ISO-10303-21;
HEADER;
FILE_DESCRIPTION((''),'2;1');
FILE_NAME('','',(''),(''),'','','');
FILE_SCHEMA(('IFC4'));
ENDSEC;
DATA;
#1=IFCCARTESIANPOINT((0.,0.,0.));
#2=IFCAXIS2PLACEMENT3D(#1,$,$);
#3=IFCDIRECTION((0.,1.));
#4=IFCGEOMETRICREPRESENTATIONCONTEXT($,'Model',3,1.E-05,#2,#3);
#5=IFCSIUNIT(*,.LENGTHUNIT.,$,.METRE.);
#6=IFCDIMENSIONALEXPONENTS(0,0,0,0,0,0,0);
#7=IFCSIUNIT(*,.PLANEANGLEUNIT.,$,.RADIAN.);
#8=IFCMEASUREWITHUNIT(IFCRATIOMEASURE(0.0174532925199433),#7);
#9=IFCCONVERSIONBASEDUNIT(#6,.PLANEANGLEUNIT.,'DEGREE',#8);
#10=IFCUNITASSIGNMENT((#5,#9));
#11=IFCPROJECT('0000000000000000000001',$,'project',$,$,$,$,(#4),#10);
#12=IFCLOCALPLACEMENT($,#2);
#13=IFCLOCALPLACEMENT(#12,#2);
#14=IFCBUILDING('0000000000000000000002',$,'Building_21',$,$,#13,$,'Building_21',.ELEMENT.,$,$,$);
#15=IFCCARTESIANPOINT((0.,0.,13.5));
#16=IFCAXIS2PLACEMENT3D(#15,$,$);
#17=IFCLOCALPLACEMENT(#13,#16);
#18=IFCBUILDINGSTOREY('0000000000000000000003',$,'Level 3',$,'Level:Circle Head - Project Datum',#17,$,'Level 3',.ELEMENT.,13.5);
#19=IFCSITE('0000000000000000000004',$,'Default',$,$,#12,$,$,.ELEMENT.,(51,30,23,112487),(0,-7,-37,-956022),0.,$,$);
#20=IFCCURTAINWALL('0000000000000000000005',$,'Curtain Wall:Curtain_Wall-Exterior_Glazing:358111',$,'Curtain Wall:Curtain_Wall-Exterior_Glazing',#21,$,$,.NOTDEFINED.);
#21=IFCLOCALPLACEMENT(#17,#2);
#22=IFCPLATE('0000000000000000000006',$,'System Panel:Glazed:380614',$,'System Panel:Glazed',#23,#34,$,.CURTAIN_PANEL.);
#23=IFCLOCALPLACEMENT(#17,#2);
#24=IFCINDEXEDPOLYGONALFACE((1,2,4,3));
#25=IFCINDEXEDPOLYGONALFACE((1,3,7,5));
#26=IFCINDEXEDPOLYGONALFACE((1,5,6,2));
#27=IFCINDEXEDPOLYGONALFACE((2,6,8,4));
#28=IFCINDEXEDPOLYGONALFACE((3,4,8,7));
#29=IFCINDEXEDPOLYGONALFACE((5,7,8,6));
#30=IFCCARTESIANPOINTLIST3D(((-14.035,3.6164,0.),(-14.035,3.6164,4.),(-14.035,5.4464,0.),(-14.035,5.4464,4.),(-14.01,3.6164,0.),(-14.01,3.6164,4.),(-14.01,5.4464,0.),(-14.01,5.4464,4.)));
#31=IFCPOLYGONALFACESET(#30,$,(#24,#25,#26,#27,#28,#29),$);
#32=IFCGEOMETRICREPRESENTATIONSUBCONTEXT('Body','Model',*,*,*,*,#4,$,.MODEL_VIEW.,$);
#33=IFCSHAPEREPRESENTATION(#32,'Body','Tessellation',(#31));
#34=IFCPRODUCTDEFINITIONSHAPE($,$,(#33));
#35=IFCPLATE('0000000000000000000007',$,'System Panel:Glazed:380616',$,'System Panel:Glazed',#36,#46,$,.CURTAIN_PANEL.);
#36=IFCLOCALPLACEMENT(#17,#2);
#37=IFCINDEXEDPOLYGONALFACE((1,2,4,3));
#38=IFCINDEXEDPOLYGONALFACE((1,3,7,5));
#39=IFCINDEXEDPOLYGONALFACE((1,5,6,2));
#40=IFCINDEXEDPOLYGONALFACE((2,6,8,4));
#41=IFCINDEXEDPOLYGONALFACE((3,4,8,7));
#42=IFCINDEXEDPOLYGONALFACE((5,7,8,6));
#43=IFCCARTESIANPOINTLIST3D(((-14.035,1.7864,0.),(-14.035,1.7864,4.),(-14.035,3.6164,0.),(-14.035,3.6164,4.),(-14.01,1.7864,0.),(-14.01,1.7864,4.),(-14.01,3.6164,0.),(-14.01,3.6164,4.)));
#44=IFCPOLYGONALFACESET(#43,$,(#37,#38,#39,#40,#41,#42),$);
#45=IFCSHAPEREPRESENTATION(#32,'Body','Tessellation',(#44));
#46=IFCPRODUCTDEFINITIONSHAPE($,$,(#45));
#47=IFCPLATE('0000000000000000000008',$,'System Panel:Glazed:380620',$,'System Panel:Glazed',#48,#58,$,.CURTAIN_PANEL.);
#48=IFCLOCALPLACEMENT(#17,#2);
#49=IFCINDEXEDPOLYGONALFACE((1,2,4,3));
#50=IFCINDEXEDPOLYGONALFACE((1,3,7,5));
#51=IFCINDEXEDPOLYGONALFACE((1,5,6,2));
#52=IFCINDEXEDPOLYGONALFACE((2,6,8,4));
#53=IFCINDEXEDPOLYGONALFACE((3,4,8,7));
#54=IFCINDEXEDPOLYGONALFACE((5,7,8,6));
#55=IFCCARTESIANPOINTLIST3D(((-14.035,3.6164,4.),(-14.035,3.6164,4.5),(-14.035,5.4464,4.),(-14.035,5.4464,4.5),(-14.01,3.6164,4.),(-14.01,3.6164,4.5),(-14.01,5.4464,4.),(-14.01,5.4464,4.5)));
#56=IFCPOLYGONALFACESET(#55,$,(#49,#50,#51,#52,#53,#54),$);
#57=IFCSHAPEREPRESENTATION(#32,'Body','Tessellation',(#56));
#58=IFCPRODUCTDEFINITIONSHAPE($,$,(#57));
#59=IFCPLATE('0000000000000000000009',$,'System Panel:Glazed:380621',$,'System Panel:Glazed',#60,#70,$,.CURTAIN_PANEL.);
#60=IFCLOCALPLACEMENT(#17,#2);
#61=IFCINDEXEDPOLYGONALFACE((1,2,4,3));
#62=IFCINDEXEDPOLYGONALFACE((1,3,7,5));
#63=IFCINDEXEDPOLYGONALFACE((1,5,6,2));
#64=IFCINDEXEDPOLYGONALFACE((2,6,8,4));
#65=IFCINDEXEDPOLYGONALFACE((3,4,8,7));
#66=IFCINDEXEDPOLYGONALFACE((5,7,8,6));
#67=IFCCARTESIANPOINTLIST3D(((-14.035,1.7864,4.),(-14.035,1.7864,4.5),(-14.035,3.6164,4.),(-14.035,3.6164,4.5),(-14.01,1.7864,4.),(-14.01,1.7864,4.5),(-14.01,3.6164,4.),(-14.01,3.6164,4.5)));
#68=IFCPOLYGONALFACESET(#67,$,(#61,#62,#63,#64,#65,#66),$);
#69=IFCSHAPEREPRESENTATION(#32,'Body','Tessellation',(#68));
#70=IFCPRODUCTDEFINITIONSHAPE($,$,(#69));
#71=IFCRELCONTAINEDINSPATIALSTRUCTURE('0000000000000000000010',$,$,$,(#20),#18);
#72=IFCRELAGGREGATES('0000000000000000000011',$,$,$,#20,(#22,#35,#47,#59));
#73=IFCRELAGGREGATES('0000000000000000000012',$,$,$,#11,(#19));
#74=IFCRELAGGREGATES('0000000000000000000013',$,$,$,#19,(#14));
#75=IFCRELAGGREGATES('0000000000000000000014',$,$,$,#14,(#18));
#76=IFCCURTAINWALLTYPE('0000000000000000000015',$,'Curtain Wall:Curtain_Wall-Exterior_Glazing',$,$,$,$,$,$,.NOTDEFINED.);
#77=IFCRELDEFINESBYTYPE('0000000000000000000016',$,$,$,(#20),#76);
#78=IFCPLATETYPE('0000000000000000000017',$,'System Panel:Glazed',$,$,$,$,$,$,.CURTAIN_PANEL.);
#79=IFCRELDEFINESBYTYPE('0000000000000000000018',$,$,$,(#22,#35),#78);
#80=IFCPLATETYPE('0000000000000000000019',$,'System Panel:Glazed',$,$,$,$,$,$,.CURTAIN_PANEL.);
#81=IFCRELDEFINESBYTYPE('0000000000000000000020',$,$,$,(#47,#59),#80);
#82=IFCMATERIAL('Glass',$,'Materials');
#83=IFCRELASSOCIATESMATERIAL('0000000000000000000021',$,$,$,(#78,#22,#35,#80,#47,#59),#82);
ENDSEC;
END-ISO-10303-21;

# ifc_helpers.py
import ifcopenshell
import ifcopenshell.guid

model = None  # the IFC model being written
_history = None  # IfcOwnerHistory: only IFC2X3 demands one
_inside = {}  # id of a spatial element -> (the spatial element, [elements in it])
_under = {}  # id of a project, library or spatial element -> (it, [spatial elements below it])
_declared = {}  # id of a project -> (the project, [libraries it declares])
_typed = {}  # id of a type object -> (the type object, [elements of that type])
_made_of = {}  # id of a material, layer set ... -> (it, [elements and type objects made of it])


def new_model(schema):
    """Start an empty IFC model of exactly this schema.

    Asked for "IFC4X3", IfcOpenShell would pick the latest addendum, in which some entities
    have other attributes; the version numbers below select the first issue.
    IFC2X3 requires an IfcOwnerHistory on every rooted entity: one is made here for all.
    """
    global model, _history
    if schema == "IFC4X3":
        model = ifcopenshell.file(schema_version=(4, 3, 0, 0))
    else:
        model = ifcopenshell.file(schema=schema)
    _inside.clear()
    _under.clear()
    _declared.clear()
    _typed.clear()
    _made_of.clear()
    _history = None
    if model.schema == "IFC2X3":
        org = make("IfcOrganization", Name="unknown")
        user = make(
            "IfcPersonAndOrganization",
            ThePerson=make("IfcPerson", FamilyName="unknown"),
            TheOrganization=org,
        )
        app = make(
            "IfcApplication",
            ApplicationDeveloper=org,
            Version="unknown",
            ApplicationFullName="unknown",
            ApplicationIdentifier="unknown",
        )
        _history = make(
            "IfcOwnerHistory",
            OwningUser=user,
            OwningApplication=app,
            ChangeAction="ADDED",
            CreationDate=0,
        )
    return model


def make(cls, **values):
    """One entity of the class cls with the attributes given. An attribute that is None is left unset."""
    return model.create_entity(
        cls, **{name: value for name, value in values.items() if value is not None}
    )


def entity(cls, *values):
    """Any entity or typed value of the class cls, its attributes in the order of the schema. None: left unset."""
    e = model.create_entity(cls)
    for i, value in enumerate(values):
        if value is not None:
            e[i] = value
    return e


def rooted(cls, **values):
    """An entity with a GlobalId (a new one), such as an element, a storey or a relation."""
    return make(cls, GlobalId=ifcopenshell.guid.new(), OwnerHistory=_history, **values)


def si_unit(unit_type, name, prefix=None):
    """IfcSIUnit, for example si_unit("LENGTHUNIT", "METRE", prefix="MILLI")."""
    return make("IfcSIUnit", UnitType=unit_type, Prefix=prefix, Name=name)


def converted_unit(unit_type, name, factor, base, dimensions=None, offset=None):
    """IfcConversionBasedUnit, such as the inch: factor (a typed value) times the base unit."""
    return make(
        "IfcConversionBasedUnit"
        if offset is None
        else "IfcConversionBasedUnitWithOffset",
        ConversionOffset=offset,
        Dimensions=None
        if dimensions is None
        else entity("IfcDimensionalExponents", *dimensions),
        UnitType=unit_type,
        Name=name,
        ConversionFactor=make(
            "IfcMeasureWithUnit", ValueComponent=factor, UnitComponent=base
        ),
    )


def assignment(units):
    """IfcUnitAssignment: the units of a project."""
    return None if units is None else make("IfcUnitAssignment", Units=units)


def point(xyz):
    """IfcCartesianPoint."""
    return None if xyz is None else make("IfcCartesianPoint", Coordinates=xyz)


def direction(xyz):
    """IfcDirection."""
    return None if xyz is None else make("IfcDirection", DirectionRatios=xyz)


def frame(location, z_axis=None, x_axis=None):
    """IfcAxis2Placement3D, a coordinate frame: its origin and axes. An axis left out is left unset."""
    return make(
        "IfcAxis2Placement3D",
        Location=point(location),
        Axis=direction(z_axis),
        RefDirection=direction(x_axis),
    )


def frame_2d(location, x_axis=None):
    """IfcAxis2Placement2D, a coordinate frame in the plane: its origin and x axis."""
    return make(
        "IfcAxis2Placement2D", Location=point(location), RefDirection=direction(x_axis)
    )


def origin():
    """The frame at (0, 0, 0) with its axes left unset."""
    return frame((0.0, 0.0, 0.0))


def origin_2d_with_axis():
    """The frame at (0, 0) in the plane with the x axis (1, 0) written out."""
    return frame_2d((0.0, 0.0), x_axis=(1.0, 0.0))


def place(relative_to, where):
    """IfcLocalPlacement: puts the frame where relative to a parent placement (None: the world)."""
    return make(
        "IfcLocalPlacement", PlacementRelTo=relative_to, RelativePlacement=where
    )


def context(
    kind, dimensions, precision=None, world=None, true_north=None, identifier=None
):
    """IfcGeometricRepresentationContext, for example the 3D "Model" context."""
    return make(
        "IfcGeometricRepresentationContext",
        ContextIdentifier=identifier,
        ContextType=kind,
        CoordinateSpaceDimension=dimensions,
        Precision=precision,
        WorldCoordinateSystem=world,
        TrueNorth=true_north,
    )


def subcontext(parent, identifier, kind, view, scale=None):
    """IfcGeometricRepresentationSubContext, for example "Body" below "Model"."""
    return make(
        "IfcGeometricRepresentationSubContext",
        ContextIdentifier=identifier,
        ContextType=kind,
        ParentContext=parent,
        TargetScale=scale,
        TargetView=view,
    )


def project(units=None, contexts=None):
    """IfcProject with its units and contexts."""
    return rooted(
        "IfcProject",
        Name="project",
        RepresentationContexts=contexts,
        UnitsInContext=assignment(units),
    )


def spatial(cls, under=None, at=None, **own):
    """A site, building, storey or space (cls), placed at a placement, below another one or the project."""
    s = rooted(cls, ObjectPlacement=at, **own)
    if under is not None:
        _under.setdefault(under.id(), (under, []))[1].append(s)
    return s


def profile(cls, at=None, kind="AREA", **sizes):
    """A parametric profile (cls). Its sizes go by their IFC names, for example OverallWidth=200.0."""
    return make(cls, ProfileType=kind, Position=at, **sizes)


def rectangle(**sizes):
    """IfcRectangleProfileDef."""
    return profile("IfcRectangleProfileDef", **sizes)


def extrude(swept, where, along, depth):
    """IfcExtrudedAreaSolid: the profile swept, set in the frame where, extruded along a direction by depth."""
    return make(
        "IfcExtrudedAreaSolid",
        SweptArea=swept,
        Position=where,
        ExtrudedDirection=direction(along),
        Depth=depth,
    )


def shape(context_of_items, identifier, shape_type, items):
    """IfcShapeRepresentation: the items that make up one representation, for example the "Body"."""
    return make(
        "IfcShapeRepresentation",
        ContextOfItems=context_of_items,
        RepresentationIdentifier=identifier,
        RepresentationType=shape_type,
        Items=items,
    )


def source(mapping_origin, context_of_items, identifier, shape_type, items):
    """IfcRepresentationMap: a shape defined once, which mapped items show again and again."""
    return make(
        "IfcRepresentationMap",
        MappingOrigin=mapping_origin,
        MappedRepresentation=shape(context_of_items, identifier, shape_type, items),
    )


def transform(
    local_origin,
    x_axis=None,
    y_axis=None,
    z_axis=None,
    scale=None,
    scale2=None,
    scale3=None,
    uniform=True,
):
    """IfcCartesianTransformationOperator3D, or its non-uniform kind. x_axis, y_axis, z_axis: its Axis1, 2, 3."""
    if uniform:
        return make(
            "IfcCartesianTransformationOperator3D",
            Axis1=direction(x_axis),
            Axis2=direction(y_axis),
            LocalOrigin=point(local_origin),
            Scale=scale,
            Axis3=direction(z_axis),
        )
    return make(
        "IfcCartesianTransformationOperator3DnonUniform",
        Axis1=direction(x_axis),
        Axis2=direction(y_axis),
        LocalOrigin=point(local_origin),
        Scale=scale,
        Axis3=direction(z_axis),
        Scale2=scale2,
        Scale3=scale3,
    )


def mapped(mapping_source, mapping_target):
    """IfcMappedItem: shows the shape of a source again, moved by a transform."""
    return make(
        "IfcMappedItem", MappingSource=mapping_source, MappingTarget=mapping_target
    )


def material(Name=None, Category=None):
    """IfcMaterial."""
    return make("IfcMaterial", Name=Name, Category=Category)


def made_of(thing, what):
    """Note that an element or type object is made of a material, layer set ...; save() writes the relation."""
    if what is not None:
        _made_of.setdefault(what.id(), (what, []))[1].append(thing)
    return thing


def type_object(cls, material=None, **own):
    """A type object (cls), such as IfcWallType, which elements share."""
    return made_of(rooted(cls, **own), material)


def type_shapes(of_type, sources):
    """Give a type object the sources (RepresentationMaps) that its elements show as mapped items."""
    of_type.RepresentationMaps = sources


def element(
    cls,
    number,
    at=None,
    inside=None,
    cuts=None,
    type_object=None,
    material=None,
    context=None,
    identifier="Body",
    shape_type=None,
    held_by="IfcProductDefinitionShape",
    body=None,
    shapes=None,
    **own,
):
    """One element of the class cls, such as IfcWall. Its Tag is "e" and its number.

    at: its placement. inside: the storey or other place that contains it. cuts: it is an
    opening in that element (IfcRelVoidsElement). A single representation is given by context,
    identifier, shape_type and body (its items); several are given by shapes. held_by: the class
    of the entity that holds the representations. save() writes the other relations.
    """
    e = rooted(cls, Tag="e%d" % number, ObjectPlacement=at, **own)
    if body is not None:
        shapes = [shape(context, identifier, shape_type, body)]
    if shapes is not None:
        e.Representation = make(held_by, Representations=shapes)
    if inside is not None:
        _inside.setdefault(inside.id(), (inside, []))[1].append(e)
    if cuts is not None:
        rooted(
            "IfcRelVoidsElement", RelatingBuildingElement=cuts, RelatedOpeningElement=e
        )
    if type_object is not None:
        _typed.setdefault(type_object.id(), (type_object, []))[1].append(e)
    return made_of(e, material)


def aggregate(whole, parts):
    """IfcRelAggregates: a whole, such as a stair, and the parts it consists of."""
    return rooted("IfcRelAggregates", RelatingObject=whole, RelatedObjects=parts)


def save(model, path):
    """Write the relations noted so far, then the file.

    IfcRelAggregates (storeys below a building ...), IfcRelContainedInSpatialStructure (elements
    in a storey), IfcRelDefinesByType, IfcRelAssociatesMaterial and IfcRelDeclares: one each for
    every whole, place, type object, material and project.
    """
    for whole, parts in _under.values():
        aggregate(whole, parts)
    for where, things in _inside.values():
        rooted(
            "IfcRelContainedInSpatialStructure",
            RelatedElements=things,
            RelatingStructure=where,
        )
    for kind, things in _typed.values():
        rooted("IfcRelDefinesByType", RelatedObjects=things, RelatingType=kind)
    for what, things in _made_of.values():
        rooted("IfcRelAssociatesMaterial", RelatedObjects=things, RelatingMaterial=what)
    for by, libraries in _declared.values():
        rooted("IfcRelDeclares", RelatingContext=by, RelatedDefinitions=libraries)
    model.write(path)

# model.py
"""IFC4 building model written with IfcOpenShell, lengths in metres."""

from ifc_helpers import new_model, entity, si_unit, converted_unit, direction, frame, origin, origin_2d_with_axis, place, context, subcontext, project, spatial, rectangle, extrude, source, transform, mapped, material, type_object, type_shapes, element, aggregate, save


model = new_model("IFC4")

# Units and contexts
model_context = context("Model", 3, precision=1e-05, world=origin(), true_north=direction((0.0, 1.0)))
body_context = subcontext(model_context, "Body", "Model", "MODEL_VIEW")
ifc_project = project(units=[si_unit("LENGTHUNIT", "METRE"), converted_unit("PLANEANGLEUNIT", "DEGREE", entity("IfcRatioMeasure", 0.0174532925199433), si_unit("PLANEANGLEUNIT", "RADIAN"), dimensions=[0, 0, 0, 0, 0, 0, 0])], contexts=[model_context])

# Site, building, storey
site_placement = place(None, origin())
site = spatial("IfcSite", under=ifc_project, at=site_placement, Name="Default", CompositionType="ELEMENT", RefLatitude=(51, 30, 23, 112487), RefLongitude=(0, -7, -37, -956022), RefElevation=0.0)
building_placement = place(site_placement, origin())
building = spatial("IfcBuilding", under=site, at=building_placement, Name="Building_21", LongName="Building_21", CompositionType="ELEMENT")
storey_placement = place(building_placement, frame((0.0, 0.0, 13.5)))
storey = spatial("IfcBuildingStorey", under=building, at=storey_placement, Name="Level 3", ObjectType="Level:Circle Head - Project Datum", LongName="Level 3", CompositionType="ELEMENT", Elevation=13.5)

# Curtain wall, plates
curtain_wall_type = type_object("IfcCurtainWallType", Name="Curtain Wall:Curtain_Wall-Exterior_Glazing", PredefinedType="NOTDEFINED")
curtain_wall_placement = place(storey_placement, frame((0.0, 0.0, -13.5)))
curtain_wall = element("IfcCurtainWall", 1, at=curtain_wall_placement, inside=storey, type_object=curtain_wall_type, Name="Curtain Wall:Curtain_Wall-Exterior_Glazing:358111", ObjectType="Curtain Wall:Curtain_Wall-Exterior_Glazing", PredefinedType="NOTDEFINED")
ifc_material_1 = material(Name="Glass", Category="Materials")
plate_type_1 = type_object("IfcPlateType", Name="System Panel:Glazed", PredefinedType="CURTAIN_PANEL", material=ifc_material_1)
shared_shape_1 = source(origin(), body_context, "Body", "SweptSolid", [
    extrude(rectangle(XDim=0.025, YDim=1.83, at=origin_2d_with_axis()), frame((0.915, 0.0125, 0.0), z_axis=(0.0, 0.0, 1.0), x_axis=(0.0, 1.0, 0.0)), (0.0, 0.0, 1.0), 4.0),
])
type_shapes(plate_type_1, [shared_shape_1])
plate_1_placement = place(curtain_wall_placement, frame((-14.035, 5.4464, 13.5), z_axis=(0.0, 0.0, 1.0), x_axis=(0.0, -1.0, 0.0)))
plate_1 = element("IfcPlate", 2, at=plate_1_placement, type_object=plate_type_1, material=ifc_material_1, Name="System Panel:Glazed:380614", ObjectType="System Panel:Glazed", PredefinedType="CURTAIN_PANEL", context=body_context, shape_type="MappedRepresentation", body=[
    mapped(shared_shape_1, transform((0.0, 0.0, 0.0), scale=1.0)),
])
plate_2_placement = place(curtain_wall_placement, frame((-14.035, 3.6164, 13.5), z_axis=(0.0, 0.0, 1.0), x_axis=(0.0, -1.0, 0.0)))
plate_2 = element("IfcPlate", 3, at=plate_2_placement, type_object=plate_type_1, material=ifc_material_1, Name="System Panel:Glazed:380616", ObjectType="System Panel:Glazed", PredefinedType="CURTAIN_PANEL", context=body_context, shape_type="MappedRepresentation", body=[
    mapped(shared_shape_1, transform((0.0, 0.0, 0.0), scale=1.0)),
])
plate_type_2 = type_object("IfcPlateType", Name="System Panel:Glazed", PredefinedType="CURTAIN_PANEL", material=ifc_material_1)
shared_shape_2 = source(origin(), body_context, "Body", "SweptSolid", [
    extrude(rectangle(XDim=0.025, YDim=1.83, at=origin_2d_with_axis()), frame((0.915, 0.0125, 0.0), z_axis=(0.0, 0.0, 1.0), x_axis=(0.0, 1.0, 0.0)), (0.0, 0.0, 1.0), 0.5),
])
type_shapes(plate_type_2, [shared_shape_2])
plate_3_placement = place(curtain_wall_placement, frame((-14.035, 5.4464, 17.5), z_axis=(0.0, 0.0, 1.0), x_axis=(0.0, -1.0, 0.0)))
plate_3 = element("IfcPlate", 4, at=plate_3_placement, type_object=plate_type_2, material=ifc_material_1, Name="System Panel:Glazed:380620", ObjectType="System Panel:Glazed", PredefinedType="CURTAIN_PANEL", context=body_context, shape_type="MappedRepresentation", body=[
    mapped(shared_shape_2, transform((0.0, 0.0, 0.0), scale=1.0)),
])
plate_4_placement = place(curtain_wall_placement, frame((-14.035, 3.6164, 17.5), z_axis=(0.0, 0.0, 1.0), x_axis=(0.0, -1.0, 0.0)))
plate_4 = element("IfcPlate", 5, at=plate_4_placement, type_object=plate_type_2, material=ifc_material_1, Name="System Panel:Glazed:380621", ObjectType="System Panel:Glazed", PredefinedType="CURTAIN_PANEL", context=body_context, shape_type="MappedRepresentation", body=[
    mapped(shared_shape_2, transform((0.0, 0.0, 0.0), scale=1.0)),
])
aggregate(curtain_wall, [plate_1, plate_2, plate_3, plate_4])

save(model, "model.ifc")
